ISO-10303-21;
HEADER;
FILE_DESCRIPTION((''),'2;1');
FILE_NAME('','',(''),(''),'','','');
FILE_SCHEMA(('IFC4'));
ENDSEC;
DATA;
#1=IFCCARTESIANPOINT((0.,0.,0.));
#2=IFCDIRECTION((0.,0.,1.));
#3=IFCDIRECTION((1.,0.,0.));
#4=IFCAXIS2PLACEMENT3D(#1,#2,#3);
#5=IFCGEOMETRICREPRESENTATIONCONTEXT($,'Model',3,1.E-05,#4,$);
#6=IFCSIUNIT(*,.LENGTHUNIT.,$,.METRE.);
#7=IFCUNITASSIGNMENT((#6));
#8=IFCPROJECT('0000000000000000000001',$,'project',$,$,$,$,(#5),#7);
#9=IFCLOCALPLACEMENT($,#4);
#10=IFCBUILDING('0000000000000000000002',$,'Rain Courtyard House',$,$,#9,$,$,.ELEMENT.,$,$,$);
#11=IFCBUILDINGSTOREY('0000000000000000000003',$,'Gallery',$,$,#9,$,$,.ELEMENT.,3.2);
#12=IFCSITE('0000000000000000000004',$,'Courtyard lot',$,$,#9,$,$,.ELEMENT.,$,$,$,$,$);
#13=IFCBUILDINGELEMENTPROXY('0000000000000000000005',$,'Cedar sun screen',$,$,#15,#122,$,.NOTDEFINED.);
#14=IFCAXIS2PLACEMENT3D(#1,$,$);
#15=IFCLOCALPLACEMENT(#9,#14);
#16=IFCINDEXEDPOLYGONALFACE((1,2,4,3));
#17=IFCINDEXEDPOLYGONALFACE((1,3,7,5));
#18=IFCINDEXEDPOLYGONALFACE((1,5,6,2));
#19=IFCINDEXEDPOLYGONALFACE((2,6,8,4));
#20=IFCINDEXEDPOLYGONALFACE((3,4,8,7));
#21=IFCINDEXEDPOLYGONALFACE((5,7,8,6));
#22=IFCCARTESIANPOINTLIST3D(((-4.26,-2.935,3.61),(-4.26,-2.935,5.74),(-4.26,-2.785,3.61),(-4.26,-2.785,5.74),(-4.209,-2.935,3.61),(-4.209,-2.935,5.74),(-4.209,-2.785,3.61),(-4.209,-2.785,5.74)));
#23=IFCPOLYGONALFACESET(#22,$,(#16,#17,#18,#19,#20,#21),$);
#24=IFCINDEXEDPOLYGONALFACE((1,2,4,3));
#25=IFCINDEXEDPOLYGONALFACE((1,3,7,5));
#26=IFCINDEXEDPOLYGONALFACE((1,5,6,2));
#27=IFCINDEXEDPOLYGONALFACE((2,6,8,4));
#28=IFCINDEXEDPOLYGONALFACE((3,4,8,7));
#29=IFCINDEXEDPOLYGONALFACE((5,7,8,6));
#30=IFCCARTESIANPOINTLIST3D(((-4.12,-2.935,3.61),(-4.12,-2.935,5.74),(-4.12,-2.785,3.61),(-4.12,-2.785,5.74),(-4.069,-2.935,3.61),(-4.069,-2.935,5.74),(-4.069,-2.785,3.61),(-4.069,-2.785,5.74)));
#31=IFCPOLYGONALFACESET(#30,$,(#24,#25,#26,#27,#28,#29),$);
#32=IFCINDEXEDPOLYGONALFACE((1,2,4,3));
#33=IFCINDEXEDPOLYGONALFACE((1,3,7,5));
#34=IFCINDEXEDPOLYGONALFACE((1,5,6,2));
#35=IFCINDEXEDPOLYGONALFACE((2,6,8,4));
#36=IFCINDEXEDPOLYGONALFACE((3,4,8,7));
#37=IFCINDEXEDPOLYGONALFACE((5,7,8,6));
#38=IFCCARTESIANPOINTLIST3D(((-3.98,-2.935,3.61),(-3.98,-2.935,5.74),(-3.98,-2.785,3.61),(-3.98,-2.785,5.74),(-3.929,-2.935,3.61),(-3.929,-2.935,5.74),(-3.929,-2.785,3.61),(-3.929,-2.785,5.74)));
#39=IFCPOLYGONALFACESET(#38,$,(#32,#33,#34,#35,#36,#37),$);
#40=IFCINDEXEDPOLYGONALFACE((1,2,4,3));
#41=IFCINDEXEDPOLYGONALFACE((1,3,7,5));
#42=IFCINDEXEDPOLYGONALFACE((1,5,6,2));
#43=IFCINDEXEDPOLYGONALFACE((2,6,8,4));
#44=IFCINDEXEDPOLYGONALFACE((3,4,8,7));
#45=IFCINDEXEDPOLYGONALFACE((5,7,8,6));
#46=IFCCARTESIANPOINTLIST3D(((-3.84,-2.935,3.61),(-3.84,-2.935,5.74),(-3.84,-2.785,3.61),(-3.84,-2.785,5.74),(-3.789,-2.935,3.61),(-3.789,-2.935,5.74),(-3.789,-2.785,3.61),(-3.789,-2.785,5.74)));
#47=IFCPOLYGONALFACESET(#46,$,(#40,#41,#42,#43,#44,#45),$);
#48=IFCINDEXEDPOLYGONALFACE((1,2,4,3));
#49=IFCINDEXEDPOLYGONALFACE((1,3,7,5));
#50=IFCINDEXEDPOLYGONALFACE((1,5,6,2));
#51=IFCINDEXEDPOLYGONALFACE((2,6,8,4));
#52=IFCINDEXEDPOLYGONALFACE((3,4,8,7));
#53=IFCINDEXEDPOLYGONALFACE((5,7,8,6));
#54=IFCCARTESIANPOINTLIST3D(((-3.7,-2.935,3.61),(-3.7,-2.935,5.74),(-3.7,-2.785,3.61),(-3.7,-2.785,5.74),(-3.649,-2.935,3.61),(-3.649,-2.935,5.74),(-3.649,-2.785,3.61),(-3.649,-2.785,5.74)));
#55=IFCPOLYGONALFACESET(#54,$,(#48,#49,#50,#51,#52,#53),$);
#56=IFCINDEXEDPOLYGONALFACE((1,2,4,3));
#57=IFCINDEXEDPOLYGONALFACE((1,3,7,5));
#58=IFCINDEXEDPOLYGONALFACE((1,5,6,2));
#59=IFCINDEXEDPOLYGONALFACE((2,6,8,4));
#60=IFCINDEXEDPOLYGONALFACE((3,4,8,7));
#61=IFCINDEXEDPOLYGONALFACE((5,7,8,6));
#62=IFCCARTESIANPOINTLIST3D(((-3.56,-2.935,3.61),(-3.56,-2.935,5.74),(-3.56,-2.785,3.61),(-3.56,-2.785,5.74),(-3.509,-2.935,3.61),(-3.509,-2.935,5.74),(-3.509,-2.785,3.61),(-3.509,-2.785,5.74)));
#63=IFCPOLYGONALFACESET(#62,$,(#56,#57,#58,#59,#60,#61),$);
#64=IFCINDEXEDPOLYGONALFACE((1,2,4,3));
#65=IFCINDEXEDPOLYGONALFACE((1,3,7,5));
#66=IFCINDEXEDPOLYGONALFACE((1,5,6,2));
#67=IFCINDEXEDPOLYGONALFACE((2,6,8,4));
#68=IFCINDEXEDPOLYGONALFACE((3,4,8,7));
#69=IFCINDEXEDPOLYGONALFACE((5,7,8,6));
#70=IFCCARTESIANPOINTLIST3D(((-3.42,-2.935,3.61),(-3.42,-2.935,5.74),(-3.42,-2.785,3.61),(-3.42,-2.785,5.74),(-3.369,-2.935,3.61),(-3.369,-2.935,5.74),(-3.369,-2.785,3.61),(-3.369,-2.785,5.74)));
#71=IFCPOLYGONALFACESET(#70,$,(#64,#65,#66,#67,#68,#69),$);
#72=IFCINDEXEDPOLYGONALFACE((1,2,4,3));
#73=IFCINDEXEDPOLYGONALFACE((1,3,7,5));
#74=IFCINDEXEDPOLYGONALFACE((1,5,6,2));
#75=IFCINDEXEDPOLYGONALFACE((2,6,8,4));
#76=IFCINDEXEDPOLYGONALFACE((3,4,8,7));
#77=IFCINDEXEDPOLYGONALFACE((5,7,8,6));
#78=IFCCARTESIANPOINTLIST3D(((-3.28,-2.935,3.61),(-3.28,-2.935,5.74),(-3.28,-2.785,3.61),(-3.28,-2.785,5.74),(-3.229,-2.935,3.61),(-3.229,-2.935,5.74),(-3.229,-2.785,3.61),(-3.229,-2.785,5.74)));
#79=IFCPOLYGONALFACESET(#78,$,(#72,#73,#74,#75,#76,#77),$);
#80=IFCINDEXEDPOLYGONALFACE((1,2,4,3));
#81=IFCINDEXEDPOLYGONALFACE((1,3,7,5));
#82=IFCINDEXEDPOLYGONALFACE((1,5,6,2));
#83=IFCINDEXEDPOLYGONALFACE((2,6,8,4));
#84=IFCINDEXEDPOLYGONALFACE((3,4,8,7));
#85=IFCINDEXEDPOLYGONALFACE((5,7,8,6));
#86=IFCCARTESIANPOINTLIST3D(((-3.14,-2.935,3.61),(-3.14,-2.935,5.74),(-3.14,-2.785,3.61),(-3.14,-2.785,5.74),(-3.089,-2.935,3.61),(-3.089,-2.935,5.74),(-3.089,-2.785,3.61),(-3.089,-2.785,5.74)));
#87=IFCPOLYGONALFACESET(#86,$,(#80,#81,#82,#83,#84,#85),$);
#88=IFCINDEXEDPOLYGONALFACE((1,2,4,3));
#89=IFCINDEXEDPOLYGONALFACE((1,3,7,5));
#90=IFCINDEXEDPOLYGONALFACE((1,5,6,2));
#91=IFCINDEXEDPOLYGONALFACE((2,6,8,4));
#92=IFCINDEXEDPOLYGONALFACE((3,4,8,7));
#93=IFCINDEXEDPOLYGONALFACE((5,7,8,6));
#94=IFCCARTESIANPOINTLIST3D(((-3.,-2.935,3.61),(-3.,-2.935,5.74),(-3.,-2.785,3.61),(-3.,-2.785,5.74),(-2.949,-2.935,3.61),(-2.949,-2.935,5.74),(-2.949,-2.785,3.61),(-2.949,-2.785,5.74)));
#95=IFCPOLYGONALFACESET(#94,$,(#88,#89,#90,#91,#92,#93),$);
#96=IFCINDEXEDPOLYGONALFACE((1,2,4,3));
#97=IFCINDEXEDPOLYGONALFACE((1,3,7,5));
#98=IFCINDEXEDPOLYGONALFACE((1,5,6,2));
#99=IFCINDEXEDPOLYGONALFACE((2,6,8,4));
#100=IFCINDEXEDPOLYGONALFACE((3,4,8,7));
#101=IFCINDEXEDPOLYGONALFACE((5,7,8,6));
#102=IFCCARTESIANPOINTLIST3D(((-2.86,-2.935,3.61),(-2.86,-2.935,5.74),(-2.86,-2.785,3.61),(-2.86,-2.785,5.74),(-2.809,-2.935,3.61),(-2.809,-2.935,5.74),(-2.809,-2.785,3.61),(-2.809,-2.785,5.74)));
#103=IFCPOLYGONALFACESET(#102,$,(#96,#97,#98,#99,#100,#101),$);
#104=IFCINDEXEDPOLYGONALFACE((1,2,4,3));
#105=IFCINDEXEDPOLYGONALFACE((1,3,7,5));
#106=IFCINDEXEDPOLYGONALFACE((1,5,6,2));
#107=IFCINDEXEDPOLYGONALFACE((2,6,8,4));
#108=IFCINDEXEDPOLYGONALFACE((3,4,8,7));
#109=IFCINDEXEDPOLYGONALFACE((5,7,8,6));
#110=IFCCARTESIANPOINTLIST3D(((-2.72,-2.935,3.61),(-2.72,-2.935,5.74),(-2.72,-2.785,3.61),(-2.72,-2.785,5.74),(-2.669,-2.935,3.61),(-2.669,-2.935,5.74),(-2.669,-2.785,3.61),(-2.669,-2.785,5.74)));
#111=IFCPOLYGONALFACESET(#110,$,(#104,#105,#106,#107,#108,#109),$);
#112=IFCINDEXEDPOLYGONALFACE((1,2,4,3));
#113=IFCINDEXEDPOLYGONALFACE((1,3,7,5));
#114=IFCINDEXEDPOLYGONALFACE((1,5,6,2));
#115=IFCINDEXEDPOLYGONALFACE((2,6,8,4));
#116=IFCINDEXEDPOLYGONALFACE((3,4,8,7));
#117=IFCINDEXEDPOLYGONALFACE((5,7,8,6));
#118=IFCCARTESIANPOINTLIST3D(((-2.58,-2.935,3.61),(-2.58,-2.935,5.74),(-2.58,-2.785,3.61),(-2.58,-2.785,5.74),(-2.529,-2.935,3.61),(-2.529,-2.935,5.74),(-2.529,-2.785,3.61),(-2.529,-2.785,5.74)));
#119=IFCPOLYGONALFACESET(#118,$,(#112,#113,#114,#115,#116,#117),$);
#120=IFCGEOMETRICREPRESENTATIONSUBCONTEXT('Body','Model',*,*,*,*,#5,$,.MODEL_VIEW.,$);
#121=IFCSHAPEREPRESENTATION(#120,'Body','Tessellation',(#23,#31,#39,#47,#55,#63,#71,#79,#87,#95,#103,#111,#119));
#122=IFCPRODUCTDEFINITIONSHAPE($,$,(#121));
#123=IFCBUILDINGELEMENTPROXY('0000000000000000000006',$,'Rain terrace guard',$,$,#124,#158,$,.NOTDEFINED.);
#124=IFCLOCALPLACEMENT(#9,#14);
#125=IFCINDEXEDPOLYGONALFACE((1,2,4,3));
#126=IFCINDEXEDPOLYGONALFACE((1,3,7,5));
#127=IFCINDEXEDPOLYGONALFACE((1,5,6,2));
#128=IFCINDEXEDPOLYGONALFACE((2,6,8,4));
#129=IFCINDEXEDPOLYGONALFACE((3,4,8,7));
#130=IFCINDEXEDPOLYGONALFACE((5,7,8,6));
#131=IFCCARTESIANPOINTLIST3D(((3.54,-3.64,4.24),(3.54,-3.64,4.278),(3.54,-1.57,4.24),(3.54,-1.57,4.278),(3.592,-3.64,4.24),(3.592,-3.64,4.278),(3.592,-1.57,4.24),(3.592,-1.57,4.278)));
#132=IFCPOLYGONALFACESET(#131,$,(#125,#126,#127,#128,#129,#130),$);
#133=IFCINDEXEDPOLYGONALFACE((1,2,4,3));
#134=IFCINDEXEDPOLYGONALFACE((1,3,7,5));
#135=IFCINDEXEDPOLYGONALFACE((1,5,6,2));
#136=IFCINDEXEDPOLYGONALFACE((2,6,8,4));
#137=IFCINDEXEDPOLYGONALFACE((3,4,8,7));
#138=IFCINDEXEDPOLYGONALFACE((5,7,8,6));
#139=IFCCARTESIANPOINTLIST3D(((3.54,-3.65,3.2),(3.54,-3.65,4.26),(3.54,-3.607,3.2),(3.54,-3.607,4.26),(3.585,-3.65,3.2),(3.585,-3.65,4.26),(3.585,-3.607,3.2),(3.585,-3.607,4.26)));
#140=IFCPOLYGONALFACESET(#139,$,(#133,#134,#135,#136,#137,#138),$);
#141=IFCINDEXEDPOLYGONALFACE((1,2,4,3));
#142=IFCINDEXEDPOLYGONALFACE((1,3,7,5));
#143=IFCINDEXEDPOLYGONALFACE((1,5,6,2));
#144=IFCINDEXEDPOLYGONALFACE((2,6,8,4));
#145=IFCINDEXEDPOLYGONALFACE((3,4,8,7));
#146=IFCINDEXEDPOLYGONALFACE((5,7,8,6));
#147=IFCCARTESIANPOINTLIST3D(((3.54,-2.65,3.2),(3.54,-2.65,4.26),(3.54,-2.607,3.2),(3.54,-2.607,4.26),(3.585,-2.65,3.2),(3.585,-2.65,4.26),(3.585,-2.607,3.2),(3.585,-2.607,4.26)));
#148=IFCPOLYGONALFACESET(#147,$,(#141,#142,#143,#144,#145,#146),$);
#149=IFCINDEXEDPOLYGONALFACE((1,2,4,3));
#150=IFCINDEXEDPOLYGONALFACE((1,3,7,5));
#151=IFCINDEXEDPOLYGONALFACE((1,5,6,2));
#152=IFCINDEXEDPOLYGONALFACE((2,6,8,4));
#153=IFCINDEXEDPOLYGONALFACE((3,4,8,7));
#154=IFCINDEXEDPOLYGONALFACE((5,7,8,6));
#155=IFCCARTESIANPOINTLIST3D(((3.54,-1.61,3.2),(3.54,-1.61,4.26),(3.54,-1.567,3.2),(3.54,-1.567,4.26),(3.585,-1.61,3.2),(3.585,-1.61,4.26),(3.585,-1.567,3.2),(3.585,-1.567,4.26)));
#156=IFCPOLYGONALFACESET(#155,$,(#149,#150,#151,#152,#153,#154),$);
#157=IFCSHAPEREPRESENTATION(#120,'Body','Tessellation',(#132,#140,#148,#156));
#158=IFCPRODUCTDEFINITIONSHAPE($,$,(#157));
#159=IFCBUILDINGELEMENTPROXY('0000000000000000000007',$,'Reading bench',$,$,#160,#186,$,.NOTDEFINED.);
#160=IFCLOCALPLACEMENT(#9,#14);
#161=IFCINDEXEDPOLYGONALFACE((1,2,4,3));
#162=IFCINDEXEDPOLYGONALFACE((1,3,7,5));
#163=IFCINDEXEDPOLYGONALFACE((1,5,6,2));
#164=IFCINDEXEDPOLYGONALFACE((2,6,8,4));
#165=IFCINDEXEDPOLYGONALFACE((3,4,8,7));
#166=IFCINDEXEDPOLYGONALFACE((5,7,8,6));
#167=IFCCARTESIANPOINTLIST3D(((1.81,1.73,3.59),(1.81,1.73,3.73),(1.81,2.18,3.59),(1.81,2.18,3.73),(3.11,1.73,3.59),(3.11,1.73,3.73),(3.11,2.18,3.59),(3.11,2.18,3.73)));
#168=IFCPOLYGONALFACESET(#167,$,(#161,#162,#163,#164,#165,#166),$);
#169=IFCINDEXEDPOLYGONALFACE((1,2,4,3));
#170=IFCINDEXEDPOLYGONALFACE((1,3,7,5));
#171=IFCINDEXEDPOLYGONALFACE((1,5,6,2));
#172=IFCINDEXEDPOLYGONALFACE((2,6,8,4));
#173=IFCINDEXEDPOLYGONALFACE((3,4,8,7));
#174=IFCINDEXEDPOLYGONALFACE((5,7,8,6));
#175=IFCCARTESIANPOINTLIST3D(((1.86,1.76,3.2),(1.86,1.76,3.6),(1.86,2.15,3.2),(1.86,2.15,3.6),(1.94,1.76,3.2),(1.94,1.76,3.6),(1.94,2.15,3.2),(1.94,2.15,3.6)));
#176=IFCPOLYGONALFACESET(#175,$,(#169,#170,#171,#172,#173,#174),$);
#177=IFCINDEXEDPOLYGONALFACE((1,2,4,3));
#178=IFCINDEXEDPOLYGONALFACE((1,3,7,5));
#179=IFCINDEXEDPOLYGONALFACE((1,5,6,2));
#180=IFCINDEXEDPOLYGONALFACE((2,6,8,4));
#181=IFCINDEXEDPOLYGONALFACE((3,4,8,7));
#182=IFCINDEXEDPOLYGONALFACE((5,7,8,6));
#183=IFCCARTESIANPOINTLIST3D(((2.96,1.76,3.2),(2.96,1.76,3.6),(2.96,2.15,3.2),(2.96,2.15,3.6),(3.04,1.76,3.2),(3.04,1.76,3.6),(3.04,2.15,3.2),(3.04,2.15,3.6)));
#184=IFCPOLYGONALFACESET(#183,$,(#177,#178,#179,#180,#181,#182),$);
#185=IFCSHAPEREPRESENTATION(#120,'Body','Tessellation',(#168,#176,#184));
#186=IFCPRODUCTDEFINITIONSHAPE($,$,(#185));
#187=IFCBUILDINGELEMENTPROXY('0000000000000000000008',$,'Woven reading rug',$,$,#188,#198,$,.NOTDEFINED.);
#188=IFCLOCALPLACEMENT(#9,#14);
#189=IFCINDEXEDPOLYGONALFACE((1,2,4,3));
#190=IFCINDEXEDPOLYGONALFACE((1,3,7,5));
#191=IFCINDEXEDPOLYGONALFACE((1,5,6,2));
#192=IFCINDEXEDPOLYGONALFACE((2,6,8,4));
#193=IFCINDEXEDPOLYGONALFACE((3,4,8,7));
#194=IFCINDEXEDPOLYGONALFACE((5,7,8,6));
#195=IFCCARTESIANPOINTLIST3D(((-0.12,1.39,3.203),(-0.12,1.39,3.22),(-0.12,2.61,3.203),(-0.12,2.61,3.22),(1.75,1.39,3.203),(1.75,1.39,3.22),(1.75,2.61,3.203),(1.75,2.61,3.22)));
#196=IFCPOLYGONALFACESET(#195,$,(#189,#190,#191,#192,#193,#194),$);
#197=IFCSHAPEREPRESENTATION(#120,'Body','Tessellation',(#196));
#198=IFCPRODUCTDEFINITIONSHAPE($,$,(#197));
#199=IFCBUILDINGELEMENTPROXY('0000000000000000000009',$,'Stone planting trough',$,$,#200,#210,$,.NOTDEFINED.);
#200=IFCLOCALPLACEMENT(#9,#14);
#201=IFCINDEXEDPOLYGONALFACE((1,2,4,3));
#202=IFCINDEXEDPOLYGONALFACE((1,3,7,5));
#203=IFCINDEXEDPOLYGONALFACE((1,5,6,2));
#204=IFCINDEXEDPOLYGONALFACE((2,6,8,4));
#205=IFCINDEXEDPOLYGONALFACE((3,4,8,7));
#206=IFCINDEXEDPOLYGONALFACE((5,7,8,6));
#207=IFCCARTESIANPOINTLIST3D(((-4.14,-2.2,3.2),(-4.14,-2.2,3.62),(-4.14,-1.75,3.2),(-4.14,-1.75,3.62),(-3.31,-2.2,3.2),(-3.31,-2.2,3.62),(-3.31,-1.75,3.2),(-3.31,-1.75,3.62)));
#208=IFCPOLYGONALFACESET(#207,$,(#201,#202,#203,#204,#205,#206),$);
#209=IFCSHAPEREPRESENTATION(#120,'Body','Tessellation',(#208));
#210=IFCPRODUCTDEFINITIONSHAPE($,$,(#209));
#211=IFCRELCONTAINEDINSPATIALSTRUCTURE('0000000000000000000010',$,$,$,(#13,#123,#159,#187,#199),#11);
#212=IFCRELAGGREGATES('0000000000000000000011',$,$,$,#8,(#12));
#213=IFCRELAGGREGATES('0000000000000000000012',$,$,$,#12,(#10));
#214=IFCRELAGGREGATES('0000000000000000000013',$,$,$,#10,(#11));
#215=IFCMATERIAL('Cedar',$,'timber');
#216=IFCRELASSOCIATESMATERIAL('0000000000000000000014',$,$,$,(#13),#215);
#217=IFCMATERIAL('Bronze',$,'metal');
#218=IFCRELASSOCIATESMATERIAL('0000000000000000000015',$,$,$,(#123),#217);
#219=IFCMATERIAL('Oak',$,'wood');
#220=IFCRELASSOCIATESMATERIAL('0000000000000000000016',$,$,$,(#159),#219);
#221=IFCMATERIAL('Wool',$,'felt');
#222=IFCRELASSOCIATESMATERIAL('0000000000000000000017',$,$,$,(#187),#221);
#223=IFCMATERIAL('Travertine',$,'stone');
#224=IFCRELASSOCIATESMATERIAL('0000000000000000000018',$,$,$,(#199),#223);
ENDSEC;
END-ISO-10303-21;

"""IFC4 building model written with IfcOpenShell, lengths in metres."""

from ifc_helpers import new_model, si_unit, frame, origin_with_axes, origin_2d, place, context, subcontext, project, spatial, rectangle, extrude, material, element, save


model = new_model("IFC4")

# Units and contexts
model_context = context("Model", 3, precision=1e-05, world=origin_with_axes())
body_context = subcontext(model_context, "Body", "Model", "MODEL_VIEW")
ifc_project = project(units=[si_unit("LENGTHUNIT", "METRE")], contexts=[model_context])

# Site, building, storey
placement = place(None, origin_with_axes())
site = spatial("IfcSite", under=ifc_project, at=placement, Name="Courtyard lot", CompositionType="ELEMENT")
building = spatial("IfcBuilding", under=site, at=placement, Name="Rain Courtyard House", CompositionType="ELEMENT")
storey = spatial("IfcBuildingStorey", under=building, at=placement, Name="Gallery", CompositionType="ELEMENT", Elevation=3.2)

# Building element proxies
ifc_material_1 = material(Name="Bronze", Category="metal")
ifc_material_2 = material(Name="Cedar", Category="timber")
element("IfcBuildingElementProxy", 1, at=placement, inside=storey, material=ifc_material_2, Name="Cedar sun screen", PredefinedType="NOTDEFINED", context=body_context, shape_type="SweptSolid", body=[
    extrude(rectangle(XDim=0.051, YDim=0.15, at=origin_2d()), frame((-4.2345, -2.86, 3.61), z_axis=(0.0, 0.0, 1.0), x_axis=(1.0, 0.0, 0.0)), (0.0, 0.0, 1.0), 2.13),
    extrude(rectangle(XDim=0.051, YDim=0.15, at=origin_2d()), frame((-4.0945, -2.86, 3.61), z_axis=(0.0, 0.0, 1.0), x_axis=(1.0, 0.0, 0.0)), (0.0, 0.0, 1.0), 2.13),
    extrude(rectangle(XDim=0.051, YDim=0.15, at=origin_2d()), frame((-3.9545, -2.86, 3.61), z_axis=(0.0, 0.0, 1.0), x_axis=(1.0, 0.0, 0.0)), (0.0, 0.0, 1.0), 2.13),
    extrude(rectangle(XDim=0.051, YDim=0.15, at=origin_2d()), frame((-3.8145, -2.86, 3.61), z_axis=(0.0, 0.0, 1.0), x_axis=(1.0, 0.0, 0.0)), (0.0, 0.0, 1.0), 2.13),
    extrude(rectangle(XDim=0.051, YDim=0.15, at=origin_2d()), frame((-3.6745, -2.86, 3.61), z_axis=(0.0, 0.0, 1.0), x_axis=(1.0, 0.0, 0.0)), (0.0, 0.0, 1.0), 2.13),
    extrude(rectangle(XDim=0.051, YDim=0.15, at=origin_2d()), frame((-3.5345, -2.86, 3.61), z_axis=(0.0, 0.0, 1.0), x_axis=(1.0, 0.0, 0.0)), (0.0, 0.0, 1.0), 2.13),
    extrude(rectangle(XDim=0.051, YDim=0.15, at=origin_2d()), frame((-3.3945, -2.86, 3.61), z_axis=(0.0, 0.0, 1.0), x_axis=(1.0, 0.0, 0.0)), (0.0, 0.0, 1.0), 2.13),
    extrude(rectangle(XDim=0.051, YDim=0.15, at=origin_2d()), frame((-3.2545, -2.86, 3.61), z_axis=(0.0, 0.0, 1.0), x_axis=(1.0, 0.0, 0.0)), (0.0, 0.0, 1.0), 2.13),
    extrude(rectangle(XDim=0.051, YDim=0.15, at=origin_2d()), frame((-3.1145, -2.86, 3.61), z_axis=(0.0, 0.0, 1.0), x_axis=(1.0, 0.0, 0.0)), (0.0, 0.0, 1.0), 2.13),
    extrude(rectangle(XDim=0.051, YDim=0.15, at=origin_2d()), frame((-2.9745, -2.86, 3.61), z_axis=(0.0, 0.0, 1.0), x_axis=(1.0, 0.0, 0.0)), (0.0, 0.0, 1.0), 2.13),
    extrude(rectangle(XDim=0.051, YDim=0.15, at=origin_2d()), frame((-2.8345, -2.86, 3.61), z_axis=(0.0, 0.0, 1.0), x_axis=(1.0, 0.0, 0.0)), (0.0, 0.0, 1.0), 2.13),
    extrude(rectangle(XDim=0.051, YDim=0.15, at=origin_2d()), frame((-2.6945, -2.86, 3.61), z_axis=(0.0, 0.0, 1.0), x_axis=(1.0, 0.0, 0.0)), (0.0, 0.0, 1.0), 2.13),
    extrude(rectangle(XDim=0.051, YDim=0.15, at=origin_2d()), frame((-2.5545, -2.86, 3.61), z_axis=(0.0, 0.0, 1.0), x_axis=(1.0, 0.0, 0.0)), (0.0, 0.0, 1.0), 2.13),
])
element("IfcBuildingElementProxy", 2, at=placement, inside=storey, material=ifc_material_1, Name="Rain terrace guard", PredefinedType="NOTDEFINED", context=body_context, shape_type="SweptSolid", body=[
    extrude(rectangle(XDim=0.052, YDim=2.07, at=origin_2d()), frame((3.566, -2.605, 4.24), z_axis=(0.0, 0.0, 1.0), x_axis=(1.0, 0.0, 0.0)), (0.0, 0.0, 1.0), 0.038),
    extrude(rectangle(XDim=0.045, YDim=0.043, at=origin_2d()), frame((3.5625, -3.6285, 3.2), z_axis=(0.0, 0.0, 1.0), x_axis=(1.0, 0.0, 0.0)), (0.0, 0.0, 1.0), 1.06),
    extrude(rectangle(XDim=0.045, YDim=0.043, at=origin_2d()), frame((3.5625, -2.6285, 3.2), z_axis=(0.0, 0.0, 1.0), x_axis=(1.0, 0.0, 0.0)), (0.0, 0.0, 1.0), 1.06),
    extrude(rectangle(XDim=0.045, YDim=0.043, at=origin_2d()), frame((3.5625, -1.5885, 3.2), z_axis=(0.0, 0.0, 1.0), x_axis=(1.0, 0.0, 0.0)), (0.0, 0.0, 1.0), 1.06),
])
ifc_material_3 = material(Name="Oak", Category="wood")
element("IfcBuildingElementProxy", 3, at=placement, inside=storey, material=ifc_material_3, Name="Reading bench", PredefinedType="NOTDEFINED", context=body_context, shape_type="SweptSolid", body=[
    extrude(rectangle(XDim=1.3, YDim=0.45, at=origin_2d()), frame((2.46, 1.955, 3.59), z_axis=(0.0, 0.0, 1.0), x_axis=(1.0, 0.0, 0.0)), (0.0, 0.0, 1.0), 0.14),
    extrude(rectangle(XDim=0.08, YDim=0.39, at=origin_2d()), frame((1.9, 1.955, 3.2), z_axis=(0.0, 0.0, 1.0), x_axis=(1.0, 0.0, 0.0)), (0.0, 0.0, 1.0), 0.4),
    extrude(rectangle(XDim=0.08, YDim=0.39, at=origin_2d()), frame((3.0, 1.955, 3.2), z_axis=(0.0, 0.0, 1.0), x_axis=(1.0, 0.0, 0.0)), (0.0, 0.0, 1.0), 0.4),
])
ifc_material_4 = material(Name="Wool", Category="felt")
element("IfcBuildingElementProxy", 4, at=placement, inside=storey, material=ifc_material_4, Name="Woven reading rug", PredefinedType="NOTDEFINED", context=body_context, shape_type="SweptSolid", body=[
    extrude(rectangle(XDim=1.87, YDim=1.22, at=origin_2d()), frame((0.815, 2.0, 3.203), z_axis=(0.0, 0.0, 1.0), x_axis=(1.0, 0.0, 0.0)), (0.0, 0.0, 1.0), 0.017),
])
ifc_material_5 = material(Name="Travertine", Category="stone")
element("IfcBuildingElementProxy", 5, at=placement, inside=storey, material=ifc_material_5, Name="Stone planting trough", PredefinedType="NOTDEFINED", context=body_context, shape_type="SweptSolid", body=[
    extrude(rectangle(XDim=0.83, YDim=0.45, at=origin_2d()), frame((-3.725, -1.975, 3.2), z_axis=(0.0, 0.0, 1.0), x_axis=(1.0, 0.0, 0.0)), (0.0, 0.0, 1.0), 0.42),
])

save(model, "model.ifc")
